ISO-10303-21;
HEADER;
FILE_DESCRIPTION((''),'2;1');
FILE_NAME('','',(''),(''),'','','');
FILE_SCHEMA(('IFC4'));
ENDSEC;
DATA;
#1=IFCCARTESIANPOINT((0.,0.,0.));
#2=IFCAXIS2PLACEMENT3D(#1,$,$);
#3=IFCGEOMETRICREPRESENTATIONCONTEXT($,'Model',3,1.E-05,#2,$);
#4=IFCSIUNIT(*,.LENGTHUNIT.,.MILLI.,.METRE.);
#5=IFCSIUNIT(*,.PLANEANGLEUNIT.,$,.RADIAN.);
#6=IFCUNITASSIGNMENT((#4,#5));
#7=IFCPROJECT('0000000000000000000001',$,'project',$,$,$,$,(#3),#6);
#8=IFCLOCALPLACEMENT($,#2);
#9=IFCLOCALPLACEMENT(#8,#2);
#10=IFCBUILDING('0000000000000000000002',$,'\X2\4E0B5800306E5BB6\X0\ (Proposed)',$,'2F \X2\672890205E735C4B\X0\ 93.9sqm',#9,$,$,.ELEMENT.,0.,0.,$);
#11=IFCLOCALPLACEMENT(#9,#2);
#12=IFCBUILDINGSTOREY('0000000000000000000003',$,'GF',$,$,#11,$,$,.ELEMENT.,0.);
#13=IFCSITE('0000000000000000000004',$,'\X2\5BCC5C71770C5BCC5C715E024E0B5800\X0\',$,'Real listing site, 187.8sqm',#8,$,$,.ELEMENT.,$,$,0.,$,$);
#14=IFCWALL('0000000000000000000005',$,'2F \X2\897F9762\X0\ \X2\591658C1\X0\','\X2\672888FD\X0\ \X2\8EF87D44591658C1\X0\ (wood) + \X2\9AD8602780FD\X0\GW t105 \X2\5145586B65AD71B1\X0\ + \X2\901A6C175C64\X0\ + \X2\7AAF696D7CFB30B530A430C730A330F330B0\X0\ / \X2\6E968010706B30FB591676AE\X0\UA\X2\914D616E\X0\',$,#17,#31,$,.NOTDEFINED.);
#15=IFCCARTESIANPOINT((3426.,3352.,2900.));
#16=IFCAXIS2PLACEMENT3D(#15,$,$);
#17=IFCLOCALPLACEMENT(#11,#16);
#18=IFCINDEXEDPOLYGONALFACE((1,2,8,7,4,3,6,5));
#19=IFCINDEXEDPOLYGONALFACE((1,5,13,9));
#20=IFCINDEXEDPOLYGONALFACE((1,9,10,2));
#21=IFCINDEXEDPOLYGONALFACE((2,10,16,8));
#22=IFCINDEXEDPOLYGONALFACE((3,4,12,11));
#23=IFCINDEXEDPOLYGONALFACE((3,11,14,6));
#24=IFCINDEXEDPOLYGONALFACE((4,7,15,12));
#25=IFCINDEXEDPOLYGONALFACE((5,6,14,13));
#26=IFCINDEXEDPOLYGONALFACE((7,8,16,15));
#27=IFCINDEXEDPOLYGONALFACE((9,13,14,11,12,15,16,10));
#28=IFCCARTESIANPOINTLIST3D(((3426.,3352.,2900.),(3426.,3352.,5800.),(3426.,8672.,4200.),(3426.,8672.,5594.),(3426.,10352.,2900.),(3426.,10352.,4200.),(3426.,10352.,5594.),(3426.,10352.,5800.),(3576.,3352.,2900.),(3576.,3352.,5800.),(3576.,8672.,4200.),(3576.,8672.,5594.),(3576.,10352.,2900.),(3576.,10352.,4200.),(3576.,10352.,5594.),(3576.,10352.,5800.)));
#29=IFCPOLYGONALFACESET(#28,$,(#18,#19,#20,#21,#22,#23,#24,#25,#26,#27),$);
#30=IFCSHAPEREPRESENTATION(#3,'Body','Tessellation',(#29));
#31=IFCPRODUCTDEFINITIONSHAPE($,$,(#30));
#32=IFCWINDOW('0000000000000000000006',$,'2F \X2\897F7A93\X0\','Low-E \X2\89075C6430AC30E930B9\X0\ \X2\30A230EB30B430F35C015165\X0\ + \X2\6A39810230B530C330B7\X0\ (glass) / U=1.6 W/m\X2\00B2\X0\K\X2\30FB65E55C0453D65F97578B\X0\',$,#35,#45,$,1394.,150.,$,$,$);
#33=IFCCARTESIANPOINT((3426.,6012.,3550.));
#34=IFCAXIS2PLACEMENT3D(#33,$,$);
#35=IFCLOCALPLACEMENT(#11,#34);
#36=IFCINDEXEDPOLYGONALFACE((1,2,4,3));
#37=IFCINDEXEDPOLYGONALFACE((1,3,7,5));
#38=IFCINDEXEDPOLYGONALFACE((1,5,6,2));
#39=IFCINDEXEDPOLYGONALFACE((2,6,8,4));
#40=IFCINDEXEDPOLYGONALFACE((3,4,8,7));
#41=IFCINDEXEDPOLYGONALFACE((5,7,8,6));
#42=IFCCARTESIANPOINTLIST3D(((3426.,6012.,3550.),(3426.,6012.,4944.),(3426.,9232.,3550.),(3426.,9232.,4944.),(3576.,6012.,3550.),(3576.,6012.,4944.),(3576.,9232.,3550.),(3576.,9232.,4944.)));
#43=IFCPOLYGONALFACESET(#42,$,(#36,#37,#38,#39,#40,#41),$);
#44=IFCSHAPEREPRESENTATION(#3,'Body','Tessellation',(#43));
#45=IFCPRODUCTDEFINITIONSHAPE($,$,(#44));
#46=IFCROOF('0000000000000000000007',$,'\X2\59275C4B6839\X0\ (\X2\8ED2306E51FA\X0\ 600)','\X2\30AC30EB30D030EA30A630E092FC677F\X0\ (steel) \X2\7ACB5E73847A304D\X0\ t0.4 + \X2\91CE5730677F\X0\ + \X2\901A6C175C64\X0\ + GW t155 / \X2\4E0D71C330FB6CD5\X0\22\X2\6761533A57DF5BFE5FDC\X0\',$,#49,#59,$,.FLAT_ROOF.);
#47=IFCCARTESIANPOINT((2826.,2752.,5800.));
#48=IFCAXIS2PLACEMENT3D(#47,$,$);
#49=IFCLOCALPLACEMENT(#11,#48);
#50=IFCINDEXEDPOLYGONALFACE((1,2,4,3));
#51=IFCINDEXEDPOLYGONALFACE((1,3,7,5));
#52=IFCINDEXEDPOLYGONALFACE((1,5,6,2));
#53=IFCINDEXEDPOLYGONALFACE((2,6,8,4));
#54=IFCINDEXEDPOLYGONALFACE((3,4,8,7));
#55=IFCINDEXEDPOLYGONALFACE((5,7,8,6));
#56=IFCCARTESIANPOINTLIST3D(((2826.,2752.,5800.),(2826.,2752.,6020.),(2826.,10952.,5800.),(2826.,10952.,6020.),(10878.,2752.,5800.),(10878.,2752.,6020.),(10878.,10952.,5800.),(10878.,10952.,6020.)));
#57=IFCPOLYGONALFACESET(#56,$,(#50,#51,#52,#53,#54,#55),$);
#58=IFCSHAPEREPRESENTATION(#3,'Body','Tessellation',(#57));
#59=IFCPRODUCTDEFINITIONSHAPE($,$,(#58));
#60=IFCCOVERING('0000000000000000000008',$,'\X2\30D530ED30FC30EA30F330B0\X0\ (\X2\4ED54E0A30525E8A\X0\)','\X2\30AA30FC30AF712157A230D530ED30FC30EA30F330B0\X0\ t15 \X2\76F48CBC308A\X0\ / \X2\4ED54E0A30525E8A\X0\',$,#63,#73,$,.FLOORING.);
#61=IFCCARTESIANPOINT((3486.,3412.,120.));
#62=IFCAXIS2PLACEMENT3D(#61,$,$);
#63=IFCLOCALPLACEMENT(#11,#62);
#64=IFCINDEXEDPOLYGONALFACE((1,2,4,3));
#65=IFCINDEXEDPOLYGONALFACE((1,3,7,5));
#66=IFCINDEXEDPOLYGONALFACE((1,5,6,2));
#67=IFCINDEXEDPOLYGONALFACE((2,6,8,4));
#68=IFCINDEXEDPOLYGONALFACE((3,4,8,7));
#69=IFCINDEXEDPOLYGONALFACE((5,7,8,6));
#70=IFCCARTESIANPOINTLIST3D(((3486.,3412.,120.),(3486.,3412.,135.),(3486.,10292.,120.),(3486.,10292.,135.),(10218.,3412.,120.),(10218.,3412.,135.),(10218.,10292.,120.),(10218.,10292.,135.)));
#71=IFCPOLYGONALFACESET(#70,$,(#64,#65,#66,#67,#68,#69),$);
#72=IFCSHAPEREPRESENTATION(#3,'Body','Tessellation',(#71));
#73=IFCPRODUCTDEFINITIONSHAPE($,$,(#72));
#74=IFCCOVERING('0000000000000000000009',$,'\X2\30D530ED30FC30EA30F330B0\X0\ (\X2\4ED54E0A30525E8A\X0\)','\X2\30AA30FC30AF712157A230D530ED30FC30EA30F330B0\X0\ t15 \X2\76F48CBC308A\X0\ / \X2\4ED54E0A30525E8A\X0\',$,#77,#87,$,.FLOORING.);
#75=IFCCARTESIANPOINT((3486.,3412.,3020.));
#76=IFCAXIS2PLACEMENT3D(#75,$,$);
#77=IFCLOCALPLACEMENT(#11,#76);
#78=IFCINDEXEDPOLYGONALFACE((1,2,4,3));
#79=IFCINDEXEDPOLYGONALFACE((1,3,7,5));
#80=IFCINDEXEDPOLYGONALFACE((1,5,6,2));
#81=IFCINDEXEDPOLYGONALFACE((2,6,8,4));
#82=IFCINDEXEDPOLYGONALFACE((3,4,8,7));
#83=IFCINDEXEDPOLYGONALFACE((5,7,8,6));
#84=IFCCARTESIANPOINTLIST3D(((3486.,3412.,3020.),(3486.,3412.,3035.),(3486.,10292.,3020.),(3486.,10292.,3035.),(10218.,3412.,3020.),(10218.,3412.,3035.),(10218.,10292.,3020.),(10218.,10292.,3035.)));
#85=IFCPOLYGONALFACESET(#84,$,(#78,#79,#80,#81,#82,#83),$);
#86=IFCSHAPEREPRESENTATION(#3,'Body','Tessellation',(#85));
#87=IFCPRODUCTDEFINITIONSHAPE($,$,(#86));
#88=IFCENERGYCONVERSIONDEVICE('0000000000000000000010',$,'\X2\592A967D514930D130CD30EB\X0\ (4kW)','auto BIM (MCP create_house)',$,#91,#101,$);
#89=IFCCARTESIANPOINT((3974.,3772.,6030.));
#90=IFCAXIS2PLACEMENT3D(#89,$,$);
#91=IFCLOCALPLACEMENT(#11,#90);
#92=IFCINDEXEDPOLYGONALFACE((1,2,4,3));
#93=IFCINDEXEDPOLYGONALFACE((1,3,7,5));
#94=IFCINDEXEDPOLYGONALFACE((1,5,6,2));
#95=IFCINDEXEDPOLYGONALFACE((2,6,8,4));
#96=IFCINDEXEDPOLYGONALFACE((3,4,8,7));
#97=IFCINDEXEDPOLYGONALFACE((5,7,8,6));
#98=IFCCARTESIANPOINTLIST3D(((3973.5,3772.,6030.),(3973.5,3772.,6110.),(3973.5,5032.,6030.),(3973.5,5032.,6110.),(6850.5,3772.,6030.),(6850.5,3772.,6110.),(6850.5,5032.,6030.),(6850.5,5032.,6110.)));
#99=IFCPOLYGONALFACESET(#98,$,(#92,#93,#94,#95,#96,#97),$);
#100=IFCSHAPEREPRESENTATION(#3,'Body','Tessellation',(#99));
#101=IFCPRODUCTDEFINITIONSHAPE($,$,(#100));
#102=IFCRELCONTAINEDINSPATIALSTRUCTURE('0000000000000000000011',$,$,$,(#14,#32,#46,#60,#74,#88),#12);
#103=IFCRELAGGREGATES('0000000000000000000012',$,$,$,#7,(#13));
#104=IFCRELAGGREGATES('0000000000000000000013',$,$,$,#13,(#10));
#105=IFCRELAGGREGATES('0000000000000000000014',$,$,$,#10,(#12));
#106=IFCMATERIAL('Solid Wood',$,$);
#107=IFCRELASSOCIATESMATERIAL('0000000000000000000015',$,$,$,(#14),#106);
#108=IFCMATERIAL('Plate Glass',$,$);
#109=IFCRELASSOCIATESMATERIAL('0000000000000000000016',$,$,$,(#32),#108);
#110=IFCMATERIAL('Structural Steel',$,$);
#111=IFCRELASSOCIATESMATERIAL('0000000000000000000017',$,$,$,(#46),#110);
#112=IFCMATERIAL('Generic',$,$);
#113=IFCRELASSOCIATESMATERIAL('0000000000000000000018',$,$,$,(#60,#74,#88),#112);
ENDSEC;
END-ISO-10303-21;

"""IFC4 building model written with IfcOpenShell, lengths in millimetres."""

from ifc_helpers import new_model, si_unit, frame, frame_2d, origin, place, context, project, spatial, rectangle, extrude, material, element, fill, save


model = new_model("IFC4")

# Units and contexts
model_context = context("Model", 3, precision=1e-05, world=origin())
ifc_project = project(units=[si_unit("LENGTHUNIT", "METRE", prefix="MILLI"), si_unit("PLANEANGLEUNIT", "RADIAN")], contexts=[model_context])

# Site, building, storey
site_placement = place(None, origin())
site = spatial("IfcSite", under=ifc_project, at=site_placement, Name="富山県富山市下堀", ObjectType="Real listing site, 187.8sqm", CompositionType="ELEMENT", RefElevation=0.0)
building_placement = place(site_placement, origin())
building = spatial("IfcBuilding", under=site, at=building_placement, Name="下堀の家 (Proposed)", ObjectType="2F 木造平屋 93.9sqm", CompositionType="ELEMENT", ElevationOfRefHeight=0.0, ElevationOfTerrain=0.0)
storey_placement = place(building_placement, origin())
storey = spatial("IfcBuildingStorey", under=building, at=storey_placement, Name="GF", CompositionType="ELEMENT", Elevation=0.0)

# Shared definitions
ifc_material_1 = material(Name="Solid Wood")

# Shared definitions
ifc_material_2 = material(Name="Plate Glass")

# Wall, opening, window
wall_1_placement = place(storey_placement, frame((3426.0, 3352.0, 2900.0)))
wall_1 = element("IfcWall", 1, at=wall_1_placement, inside=storey, material=ifc_material_1, Name="2F 西面 外壁", Description="木製 軸組外壁 (wood) + 高性能GW t105 充填断熱 + 通気層 + 窯業系サイディング / 準耐火・外皮UA配慮", PredefinedType="NOTDEFINED", context=model_context, shape_type="SweptSolid", body=[
    extrude(rectangle(XDim=150.0, YDim=7000.0, at=frame_2d((75.0, 3500.0))), frame((3426.0, 3352.0, 2900.0)), (0.0, 0.0, 1.0), 2900.0),
])
opening_1_placement = place(storey_placement, frame((3426.0, 6012.0, 3550.0)))
opening_1 = element("IfcOpeningElement", 2, at=opening_1_placement, cuts=wall_1, PredefinedType="NOTDEFINED", context=model_context, shape_type="SweptSolid", body=[
    extrude(rectangle(XDim=150.0, YDim=3220.0, at=frame_2d((75.0, 1610.0))), frame((3426.0, 6012.0, 3550.0)), (0.0, 0.0, 1.0), 1394.0),
])
window_1_placement = place(storey_placement, frame((3426.0, 6012.0, 3550.0)))
window_1 = element("IfcWindow", 3, at=window_1_placement, inside=storey, material=ifc_material_2, Name="2F 西窓", Description="Low-E 複層ガラス アルゴン封入 + 樹脂サッシ (glass) / U=1.6 W/m²K・日射取得型", OverallHeight=1394.0, OverallWidth=150.0, context=model_context, shape_type="SweptSolid", body=[
    extrude(rectangle(XDim=150.0, YDim=3220.0, at=frame_2d((75.0, 1610.0))), frame((3426.0, 6012.0, 3550.0)), (0.0, 0.0, 1.0), 1394.0),
])
fill(opening_1, window_1)

# Roof
ifc_material_3 = material(Name="Structural Steel")
roof_placement = place(storey_placement, frame((2826.0, 2752.0, 5800.0)))
element("IfcRoof", 4, at=roof_placement, inside=storey, material=ifc_material_3, Name="大屋根 (軒の出 600)", Description="ガルバリウム鋼板 (steel) 立平葺き t0.4 + 野地板 + 通気層 + GW t155 / 不燃・法22条区域対応", PredefinedType="FLAT_ROOF", context=model_context, shape_type="SweptSolid", body=[
    extrude(rectangle(XDim=8052.0, YDim=8200.0, at=frame_2d((4026.0, 4100.0))), frame((2826.0, 2752.0, 5800.0)), (0.0, 0.0, 1.0), 220.0),
])

# Coverings
ifc_material_4 = material(Name="Generic")
covering_1_placement = place(storey_placement, frame((3486.0, 3412.0, 120.0)))
element("IfcCovering", 5, at=covering_1_placement, inside=storey, material=ifc_material_4, Name="フローリング (仕上げ床)", Description="オーク無垢フローリング t15 直貼り / 仕上げ床", PredefinedType="FLOORING", context=model_context, shape_type="SweptSolid", body=[
    extrude(rectangle(XDim=6732.0, YDim=6880.0, at=frame_2d((3366.0, 3440.0))), frame((3486.0, 3412.0, 120.0)), (0.0, 0.0, 1.0), 15.0),
])
covering_2_placement = place(storey_placement, frame((3486.0, 3412.0, 3020.0)))
element("IfcCovering", 6, at=covering_2_placement, inside=storey, material=ifc_material_4, Name="フローリング (仕上げ床)", Description="オーク無垢フローリング t15 直貼り / 仕上げ床", PredefinedType="FLOORING", context=model_context, shape_type="SweptSolid", body=[
    extrude(rectangle(XDim=6732.0, YDim=6880.0, at=frame_2d((3366.0, 3440.0))), frame((3486.0, 3412.0, 3020.0)), (0.0, 0.0, 1.0), 15.0),
])

# Energy conversion device
energy_conversion_device_placement = place(storey_placement, frame((3974.0, 3772.0, 6030.0)))
element("IfcEnergyConversionDevice", 7, at=energy_conversion_device_placement, inside=storey, material=ifc_material_4, Name="太陽光パネル (4kW)", Description="auto BIM (MCP create_house)", context=model_context, shape_type="SweptSolid", body=[
    extrude(rectangle(XDim=2877.0, YDim=1260.0, at=frame_2d((1438.0, 630.0))), frame((3974.0, 3772.0, 6030.0)), (0.0, 0.0, 1.0), 80.0),
])

save(model, "model.ifc")
